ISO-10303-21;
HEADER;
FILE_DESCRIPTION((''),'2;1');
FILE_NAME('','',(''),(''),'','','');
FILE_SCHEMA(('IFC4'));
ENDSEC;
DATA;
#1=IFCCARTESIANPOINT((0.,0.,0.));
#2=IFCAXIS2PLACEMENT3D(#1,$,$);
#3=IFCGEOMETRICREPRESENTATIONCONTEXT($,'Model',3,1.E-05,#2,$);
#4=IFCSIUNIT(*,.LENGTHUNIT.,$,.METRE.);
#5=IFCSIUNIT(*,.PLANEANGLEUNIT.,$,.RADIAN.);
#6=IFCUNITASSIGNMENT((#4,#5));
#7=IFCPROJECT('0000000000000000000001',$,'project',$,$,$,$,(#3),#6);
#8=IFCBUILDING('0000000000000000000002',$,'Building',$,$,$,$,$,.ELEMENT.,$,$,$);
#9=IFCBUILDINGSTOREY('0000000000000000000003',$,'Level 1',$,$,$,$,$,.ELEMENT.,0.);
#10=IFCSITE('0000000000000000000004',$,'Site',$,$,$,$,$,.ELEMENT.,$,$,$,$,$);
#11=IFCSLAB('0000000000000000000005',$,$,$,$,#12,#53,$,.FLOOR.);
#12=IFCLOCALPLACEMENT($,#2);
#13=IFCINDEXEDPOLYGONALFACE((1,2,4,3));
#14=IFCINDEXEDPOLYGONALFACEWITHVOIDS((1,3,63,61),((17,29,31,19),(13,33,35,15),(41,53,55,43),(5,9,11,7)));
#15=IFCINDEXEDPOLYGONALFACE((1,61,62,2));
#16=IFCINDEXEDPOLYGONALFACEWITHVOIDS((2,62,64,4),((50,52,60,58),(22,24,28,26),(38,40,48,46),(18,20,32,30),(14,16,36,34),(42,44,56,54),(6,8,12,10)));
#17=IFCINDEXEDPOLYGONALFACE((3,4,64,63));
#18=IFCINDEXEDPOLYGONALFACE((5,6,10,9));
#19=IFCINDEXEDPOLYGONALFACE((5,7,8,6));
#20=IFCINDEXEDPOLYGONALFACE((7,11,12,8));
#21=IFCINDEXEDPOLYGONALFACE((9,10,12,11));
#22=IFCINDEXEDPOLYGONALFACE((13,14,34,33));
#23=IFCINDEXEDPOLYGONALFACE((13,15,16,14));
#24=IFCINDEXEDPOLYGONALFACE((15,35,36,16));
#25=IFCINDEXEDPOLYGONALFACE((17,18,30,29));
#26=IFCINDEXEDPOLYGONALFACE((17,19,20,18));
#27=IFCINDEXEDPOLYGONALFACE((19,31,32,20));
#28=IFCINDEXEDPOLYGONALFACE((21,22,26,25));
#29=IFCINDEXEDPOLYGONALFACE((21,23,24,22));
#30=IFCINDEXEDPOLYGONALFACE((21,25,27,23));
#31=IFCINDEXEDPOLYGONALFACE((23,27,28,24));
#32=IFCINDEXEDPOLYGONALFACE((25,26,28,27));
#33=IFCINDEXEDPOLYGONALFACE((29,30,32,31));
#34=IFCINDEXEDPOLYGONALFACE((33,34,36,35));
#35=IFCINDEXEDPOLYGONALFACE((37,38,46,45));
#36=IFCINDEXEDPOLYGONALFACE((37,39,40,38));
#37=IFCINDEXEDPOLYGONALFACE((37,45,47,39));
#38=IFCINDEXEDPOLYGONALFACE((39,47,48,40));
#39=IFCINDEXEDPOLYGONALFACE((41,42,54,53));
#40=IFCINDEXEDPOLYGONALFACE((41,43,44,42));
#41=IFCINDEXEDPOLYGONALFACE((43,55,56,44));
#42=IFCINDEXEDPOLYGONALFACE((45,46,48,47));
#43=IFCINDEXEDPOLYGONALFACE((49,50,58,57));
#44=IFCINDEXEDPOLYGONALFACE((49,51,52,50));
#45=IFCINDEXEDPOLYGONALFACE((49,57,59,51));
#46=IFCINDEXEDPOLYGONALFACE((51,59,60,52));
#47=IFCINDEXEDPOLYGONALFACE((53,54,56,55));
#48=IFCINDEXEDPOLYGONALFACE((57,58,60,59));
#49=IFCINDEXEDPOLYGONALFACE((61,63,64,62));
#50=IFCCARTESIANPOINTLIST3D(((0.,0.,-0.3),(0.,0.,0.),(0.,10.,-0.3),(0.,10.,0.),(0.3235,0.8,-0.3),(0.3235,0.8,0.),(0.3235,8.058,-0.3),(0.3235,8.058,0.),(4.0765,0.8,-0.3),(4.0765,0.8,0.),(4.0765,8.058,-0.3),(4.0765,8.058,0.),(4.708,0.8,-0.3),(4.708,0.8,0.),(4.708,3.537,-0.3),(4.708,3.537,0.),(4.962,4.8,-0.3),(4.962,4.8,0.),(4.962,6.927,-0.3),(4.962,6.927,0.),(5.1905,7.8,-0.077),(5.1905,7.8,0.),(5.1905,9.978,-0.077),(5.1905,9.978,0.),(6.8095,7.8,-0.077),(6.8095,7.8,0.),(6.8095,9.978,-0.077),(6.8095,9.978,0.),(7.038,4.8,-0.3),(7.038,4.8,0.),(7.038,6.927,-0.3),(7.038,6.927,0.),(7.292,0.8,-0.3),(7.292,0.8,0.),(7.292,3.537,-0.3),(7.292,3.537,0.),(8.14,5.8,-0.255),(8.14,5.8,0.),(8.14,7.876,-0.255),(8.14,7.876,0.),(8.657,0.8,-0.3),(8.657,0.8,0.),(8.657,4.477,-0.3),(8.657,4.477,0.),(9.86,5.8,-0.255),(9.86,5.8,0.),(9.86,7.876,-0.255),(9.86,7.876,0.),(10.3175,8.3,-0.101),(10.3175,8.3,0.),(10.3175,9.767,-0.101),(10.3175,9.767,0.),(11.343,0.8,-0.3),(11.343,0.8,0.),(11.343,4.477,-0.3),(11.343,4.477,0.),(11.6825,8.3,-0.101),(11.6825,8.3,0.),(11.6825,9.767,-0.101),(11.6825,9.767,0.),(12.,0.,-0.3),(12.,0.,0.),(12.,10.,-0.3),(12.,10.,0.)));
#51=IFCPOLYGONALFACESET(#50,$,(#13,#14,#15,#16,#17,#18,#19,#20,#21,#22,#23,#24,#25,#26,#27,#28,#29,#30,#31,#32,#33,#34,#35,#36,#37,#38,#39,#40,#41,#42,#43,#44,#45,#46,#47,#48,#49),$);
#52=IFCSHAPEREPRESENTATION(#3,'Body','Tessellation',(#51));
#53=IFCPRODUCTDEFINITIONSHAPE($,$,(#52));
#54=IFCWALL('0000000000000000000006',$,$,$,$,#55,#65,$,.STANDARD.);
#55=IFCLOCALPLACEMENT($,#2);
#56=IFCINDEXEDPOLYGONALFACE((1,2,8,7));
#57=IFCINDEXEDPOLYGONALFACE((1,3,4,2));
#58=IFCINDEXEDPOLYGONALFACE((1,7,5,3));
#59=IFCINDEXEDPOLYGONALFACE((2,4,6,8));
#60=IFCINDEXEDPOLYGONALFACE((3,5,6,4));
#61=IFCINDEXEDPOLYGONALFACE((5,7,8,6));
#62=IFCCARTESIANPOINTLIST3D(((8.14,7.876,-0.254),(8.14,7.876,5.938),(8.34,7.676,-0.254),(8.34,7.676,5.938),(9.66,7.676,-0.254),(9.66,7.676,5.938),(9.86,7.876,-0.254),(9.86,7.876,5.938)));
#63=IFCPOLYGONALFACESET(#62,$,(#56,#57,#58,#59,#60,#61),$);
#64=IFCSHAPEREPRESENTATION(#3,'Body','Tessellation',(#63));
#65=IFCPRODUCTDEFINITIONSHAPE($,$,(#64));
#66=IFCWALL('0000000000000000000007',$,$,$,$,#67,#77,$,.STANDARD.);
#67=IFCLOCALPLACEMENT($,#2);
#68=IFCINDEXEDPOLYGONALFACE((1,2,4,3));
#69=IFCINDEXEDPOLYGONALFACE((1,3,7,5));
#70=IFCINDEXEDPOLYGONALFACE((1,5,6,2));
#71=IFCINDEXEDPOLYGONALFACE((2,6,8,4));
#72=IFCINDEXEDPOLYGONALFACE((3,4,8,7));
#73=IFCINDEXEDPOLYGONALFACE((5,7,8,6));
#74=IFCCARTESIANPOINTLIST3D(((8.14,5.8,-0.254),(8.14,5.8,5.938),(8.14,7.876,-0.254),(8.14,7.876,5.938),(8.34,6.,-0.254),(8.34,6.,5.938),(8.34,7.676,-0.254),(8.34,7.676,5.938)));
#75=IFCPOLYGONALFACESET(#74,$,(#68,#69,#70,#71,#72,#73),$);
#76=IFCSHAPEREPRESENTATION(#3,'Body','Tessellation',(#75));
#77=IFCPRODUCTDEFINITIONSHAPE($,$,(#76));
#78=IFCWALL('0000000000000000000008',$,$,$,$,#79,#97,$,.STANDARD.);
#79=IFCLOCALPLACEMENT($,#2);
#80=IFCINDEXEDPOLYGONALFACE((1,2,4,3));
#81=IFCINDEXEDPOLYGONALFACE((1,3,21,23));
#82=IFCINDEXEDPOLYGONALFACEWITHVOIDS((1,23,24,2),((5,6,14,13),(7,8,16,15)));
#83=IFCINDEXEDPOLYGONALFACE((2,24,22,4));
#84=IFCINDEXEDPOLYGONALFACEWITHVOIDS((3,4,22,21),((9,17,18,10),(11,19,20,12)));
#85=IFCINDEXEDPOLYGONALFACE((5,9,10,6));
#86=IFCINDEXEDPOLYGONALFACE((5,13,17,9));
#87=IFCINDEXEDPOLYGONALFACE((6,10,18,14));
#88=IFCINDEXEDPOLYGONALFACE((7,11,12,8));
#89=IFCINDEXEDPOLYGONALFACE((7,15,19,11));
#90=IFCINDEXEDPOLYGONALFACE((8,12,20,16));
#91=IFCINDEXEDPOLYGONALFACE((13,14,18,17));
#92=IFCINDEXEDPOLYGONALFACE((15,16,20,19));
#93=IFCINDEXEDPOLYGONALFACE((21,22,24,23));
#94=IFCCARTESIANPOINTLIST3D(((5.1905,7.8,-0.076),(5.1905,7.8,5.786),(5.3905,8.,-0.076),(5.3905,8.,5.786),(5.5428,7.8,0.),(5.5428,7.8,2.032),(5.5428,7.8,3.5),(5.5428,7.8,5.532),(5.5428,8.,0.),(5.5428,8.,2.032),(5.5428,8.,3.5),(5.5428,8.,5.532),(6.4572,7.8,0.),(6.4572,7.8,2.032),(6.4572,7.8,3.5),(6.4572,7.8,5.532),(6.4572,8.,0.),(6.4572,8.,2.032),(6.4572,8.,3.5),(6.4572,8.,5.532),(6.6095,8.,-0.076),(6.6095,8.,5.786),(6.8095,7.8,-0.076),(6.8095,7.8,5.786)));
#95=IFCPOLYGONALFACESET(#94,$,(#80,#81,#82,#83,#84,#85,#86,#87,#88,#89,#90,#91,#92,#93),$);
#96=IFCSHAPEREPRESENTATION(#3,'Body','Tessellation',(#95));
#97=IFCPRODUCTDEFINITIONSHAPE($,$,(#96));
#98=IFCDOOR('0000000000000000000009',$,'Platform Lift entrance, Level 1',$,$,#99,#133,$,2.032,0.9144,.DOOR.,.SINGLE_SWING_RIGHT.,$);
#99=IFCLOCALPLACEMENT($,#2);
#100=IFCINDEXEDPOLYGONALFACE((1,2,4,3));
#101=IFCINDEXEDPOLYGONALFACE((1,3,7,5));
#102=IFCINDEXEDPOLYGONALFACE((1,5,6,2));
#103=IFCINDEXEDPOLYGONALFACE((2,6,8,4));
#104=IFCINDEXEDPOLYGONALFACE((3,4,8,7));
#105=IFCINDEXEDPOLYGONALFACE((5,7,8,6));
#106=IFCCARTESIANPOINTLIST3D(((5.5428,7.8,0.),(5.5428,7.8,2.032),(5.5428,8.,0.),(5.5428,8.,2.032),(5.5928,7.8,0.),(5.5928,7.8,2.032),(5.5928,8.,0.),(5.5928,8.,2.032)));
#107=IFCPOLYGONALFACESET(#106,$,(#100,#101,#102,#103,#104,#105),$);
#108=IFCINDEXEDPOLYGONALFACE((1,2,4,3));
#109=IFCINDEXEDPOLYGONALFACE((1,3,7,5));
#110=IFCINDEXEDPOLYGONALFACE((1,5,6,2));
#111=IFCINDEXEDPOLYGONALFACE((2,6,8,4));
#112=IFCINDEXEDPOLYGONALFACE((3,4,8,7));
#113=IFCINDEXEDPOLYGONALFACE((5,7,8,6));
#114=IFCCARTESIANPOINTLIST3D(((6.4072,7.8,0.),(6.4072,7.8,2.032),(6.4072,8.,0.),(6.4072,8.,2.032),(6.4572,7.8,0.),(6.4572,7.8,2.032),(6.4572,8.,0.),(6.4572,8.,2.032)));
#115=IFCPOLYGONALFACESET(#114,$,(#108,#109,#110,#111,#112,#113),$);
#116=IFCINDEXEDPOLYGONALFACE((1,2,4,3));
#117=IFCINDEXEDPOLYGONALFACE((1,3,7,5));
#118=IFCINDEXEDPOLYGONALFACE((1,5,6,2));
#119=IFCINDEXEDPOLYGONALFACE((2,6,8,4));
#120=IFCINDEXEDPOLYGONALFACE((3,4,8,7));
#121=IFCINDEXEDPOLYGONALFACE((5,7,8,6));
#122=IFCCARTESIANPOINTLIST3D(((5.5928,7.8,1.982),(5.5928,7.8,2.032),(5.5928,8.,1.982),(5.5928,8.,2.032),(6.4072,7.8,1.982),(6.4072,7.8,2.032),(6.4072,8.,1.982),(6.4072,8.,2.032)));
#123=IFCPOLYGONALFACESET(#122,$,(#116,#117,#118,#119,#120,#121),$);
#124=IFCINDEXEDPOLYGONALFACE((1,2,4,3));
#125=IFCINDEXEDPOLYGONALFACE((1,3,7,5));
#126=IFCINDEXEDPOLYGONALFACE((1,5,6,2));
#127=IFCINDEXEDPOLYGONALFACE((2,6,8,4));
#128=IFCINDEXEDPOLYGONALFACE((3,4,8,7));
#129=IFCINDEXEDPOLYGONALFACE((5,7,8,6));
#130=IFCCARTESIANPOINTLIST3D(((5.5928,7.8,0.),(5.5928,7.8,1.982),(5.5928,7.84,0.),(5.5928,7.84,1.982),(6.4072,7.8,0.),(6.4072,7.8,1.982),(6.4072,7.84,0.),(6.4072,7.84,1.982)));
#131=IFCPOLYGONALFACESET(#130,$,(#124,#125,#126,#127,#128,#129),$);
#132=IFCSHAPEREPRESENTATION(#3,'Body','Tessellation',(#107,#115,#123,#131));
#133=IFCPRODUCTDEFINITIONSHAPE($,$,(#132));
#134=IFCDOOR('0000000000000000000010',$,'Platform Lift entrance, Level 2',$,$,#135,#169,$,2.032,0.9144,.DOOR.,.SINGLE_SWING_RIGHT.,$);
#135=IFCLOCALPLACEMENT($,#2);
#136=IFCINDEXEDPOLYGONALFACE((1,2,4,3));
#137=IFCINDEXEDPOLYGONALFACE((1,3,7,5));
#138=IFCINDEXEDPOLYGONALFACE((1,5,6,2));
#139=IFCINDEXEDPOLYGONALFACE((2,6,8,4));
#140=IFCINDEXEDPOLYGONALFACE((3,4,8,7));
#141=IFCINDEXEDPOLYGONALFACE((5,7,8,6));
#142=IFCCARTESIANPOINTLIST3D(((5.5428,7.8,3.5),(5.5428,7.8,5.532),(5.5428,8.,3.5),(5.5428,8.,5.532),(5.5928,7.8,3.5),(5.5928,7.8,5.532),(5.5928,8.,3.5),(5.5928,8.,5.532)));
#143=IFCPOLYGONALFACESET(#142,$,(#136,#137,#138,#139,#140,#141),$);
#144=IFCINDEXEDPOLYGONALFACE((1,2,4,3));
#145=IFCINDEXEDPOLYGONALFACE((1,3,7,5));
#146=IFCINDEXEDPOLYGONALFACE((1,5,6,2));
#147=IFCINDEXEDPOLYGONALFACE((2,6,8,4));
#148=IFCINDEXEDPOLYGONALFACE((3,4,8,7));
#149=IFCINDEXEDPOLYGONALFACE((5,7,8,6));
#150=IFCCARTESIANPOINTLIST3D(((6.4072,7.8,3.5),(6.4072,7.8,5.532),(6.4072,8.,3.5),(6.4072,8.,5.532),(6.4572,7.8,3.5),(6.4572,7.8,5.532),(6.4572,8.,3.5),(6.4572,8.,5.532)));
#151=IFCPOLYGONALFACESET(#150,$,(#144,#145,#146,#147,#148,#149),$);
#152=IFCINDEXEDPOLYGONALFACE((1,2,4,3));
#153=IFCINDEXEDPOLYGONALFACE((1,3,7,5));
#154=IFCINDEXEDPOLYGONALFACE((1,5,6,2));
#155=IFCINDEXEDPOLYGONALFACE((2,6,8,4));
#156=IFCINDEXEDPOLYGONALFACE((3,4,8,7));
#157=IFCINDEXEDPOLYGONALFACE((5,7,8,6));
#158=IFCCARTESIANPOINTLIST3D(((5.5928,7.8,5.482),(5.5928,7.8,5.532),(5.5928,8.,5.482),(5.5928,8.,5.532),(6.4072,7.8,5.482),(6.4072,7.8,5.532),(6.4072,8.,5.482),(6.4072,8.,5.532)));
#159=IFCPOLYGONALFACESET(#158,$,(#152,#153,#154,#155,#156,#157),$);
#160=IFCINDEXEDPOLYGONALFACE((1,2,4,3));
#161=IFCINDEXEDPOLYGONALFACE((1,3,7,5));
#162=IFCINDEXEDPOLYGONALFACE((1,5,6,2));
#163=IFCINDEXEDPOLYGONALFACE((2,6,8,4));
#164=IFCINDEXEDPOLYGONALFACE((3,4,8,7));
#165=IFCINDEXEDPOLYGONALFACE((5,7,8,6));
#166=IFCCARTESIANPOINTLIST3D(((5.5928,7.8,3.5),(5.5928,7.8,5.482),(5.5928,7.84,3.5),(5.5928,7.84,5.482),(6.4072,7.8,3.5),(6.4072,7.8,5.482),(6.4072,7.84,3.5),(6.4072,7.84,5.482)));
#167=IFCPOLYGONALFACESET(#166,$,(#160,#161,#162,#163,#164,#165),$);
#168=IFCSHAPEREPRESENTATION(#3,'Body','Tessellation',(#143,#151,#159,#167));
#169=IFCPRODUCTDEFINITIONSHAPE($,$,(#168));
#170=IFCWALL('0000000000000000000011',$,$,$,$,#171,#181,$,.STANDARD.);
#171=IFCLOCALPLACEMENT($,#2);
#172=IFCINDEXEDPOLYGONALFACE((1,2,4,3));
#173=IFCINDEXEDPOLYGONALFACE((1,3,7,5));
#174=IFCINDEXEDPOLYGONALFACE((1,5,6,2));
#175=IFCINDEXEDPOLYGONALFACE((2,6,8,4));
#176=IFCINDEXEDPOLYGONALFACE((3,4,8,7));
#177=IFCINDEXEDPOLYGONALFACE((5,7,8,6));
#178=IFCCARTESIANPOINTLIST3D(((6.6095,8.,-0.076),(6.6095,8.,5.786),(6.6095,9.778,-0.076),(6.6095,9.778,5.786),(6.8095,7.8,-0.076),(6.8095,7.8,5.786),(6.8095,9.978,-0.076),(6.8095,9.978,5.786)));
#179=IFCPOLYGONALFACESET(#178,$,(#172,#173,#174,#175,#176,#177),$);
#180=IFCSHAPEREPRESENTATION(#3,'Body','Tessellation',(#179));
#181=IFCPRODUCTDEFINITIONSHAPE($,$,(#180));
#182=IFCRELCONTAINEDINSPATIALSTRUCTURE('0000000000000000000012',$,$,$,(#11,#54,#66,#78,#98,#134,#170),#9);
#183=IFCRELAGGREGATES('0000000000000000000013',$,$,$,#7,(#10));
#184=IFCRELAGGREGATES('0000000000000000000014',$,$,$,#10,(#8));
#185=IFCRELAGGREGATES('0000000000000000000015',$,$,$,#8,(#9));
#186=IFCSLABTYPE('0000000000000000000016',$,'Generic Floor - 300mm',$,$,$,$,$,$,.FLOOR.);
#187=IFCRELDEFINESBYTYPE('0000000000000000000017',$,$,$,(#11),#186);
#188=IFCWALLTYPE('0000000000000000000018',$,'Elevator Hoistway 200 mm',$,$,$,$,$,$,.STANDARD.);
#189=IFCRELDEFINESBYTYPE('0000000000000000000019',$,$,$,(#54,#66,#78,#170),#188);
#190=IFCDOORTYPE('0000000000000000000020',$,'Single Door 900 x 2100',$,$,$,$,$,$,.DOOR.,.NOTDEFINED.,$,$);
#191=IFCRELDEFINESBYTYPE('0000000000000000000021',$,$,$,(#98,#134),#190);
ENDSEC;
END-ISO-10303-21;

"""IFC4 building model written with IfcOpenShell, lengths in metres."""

from ifc_helpers import new_model, si_unit, frame, frame_2d, origin, origin_with_axes, origin_2d, place, context, project, spatial, polyline, rectangle, outline, extrude, type_object, element, fill, save


model = new_model("IFC4")

# Units and contexts
model_context = context("Model", 3, precision=1e-05, world=origin())
ifc_project = project(units=[si_unit("LENGTHUNIT", "METRE"), si_unit("PLANEANGLEUNIT", "RADIAN")], contexts=[model_context])

# Site, building, storey
site = spatial("IfcSite", under=ifc_project, Name="Site", CompositionType="ELEMENT")
building = spatial("IfcBuilding", under=site, Name="Building", CompositionType="ELEMENT")
storey = spatial("IfcBuildingStorey", under=building, Name="Level 1", CompositionType="ELEMENT", Elevation=0.0)

# Slab, openings
slab_type = type_object("IfcSlabType", Name="Generic Floor - 300mm", PredefinedType="FLOOR")
slab_placement = place(None, origin())
slab = element("IfcSlab", 1, at=slab_placement, inside=storey, type_object=slab_type, PredefinedType="FLOOR", context=model_context, shape_type="SweptSolid", body=[
    extrude(outline(polyline([(0.0, 0.0), (12.0, 0.0), (12.0, 10.0), (0.0, 10.0), (0.0, 0.0)])), origin(), (0.0, 0.0, -1.0), 0.3),
])
opening_1_placement = place(None, frame((0.0, 0.0, 0.001)))
element("IfcOpeningElement", 2, at=opening_1_placement, cuts=slab, PredefinedType="OPENING", context=model_context, shape_type="SweptSolid", body=[
    extrude(outline(polyline([(0.3235, 0.8), (4.0765, 0.8), (4.0765, 8.058), (0.3235, 8.058), (0.3235, 0.8)])), origin(), (0.0, 0.0, -1.0), 0.302),
])
opening_2_placement = place(None, frame((0.0, 0.0, 0.001)))
element("IfcOpeningElement", 3, at=opening_2_placement, cuts=slab, PredefinedType="OPENING", context=model_context, shape_type="SweptSolid", body=[
    extrude(outline(polyline([(4.708, 0.8), (7.292, 0.8), (7.292, 3.537), (4.708, 3.537), (4.708, 0.8)])), origin(), (0.0, 0.0, -1.0), 0.302),
])
opening_3_placement = place(None, frame((0.0, 0.0, 0.001)))
element("IfcOpeningElement", 4, at=opening_3_placement, cuts=slab, PredefinedType="OPENING", context=model_context, shape_type="SweptSolid", body=[
    extrude(outline(polyline([(8.657, 0.8), (11.343, 0.8), (11.343, 4.477), (8.657, 4.477), (8.657, 0.8)])), origin(), (0.0, 0.0, -1.0), 0.302),
])
opening_4_placement = place(None, frame((0.0, 0.0, 0.001)))
element("IfcOpeningElement", 5, at=opening_4_placement, cuts=slab, PredefinedType="OPENING", context=model_context, shape_type="SweptSolid", body=[
    extrude(outline(polyline([(4.962, 4.8), (7.038, 4.8), (7.038, 6.927), (4.962, 6.927), (4.962, 4.8)])), origin(), (0.0, 0.0, -1.0), 0.302),
])
opening_5_placement = place(None, frame((0.0, 0.0, 0.001)))
element("IfcOpeningElement", 6, at=opening_5_placement, cuts=slab, PredefinedType="OPENING", context=model_context, shape_type="SweptSolid", body=[
    extrude(outline(polyline([(8.14, 5.8), (9.86, 5.8), (9.86, 7.876), (8.14, 7.876), (8.14, 5.8)])), origin(), (0.0, 0.0, -1.0), 0.256),
])
opening_6_placement = place(None, frame((0.0, 0.0, 0.001)))
element("IfcOpeningElement", 7, at=opening_6_placement, cuts=slab, PredefinedType="OPENING", context=model_context, shape_type="SweptSolid", body=[
    extrude(outline(polyline([(5.1905, 7.8), (6.8095, 7.8), (6.8095, 9.978), (5.1905, 9.978), (5.1905, 7.8)])), origin(), (0.0, 0.0, -1.0), 0.078),
])
opening_7_placement = place(None, frame((0.0, 0.0, 0.001)))
element("IfcOpeningElement", 8, at=opening_7_placement, cuts=slab, PredefinedType="OPENING", context=model_context, shape_type="SweptSolid", body=[
    extrude(outline(polyline([(10.3175, 8.3), (11.6825, 8.3), (11.6825, 9.767), (10.3175, 9.767), (10.3175, 8.3)])), origin(), (0.0, 0.0, -1.0), 0.102),
])

# Walls
wall_type = type_object("IfcWallType", Name="Elevator Hoistway 200 mm", PredefinedType="STANDARD")
wall_1_placement = place(None, frame((9.76, 7.776, -0.254), z_axis=(0.0, 0.0, 1.0), x_axis=(-1.0, 0.0, 0.0)))
element("IfcWall", 9, at=wall_1_placement, inside=storey, type_object=wall_type, PredefinedType="STANDARD", context=model_context, shape_type="SweptSolid", body=[
    extrude(outline(polyline([(-0.1, -0.1), (1.62, -0.1), (1.42, 0.1), (0.1, 0.1), (-0.1, -0.1)])), origin(), (0.0, 0.0, 1.0), 6.192),
])
wall_2_placement = place(None, frame((8.24, 7.776, -0.254), z_axis=(0.0, 0.0, 1.0), x_axis=(0.0, -1.0, 0.0)))
element("IfcWall", 10, at=wall_2_placement, inside=storey, type_object=wall_type, PredefinedType="STANDARD", context=model_context, shape_type="SweptSolid", body=[
    extrude(outline(polyline([(-0.1, -0.1), (1.976, -0.1), (1.776, 0.1), (0.1, 0.1), (-0.1, -0.1)])), origin(), (0.0, 0.0, 1.0), 6.192),
])

# Wall, openings, doors
wall_3_placement = place(None, frame((5.2905, 7.9, -0.076), z_axis=(0.0, 0.0, 1.0), x_axis=(1.0, 0.0, 0.0)))
wall_3 = element("IfcWall", 11, at=wall_3_placement, inside=storey, type_object=wall_type, PredefinedType="STANDARD", context=model_context, shape_type="SweptSolid", body=[
    extrude(outline(polyline([(-0.1, -0.1), (1.519, -0.1), (1.319, 0.1), (0.1, 0.1), (-0.1, -0.1)])), origin(), (0.0, 0.0, 1.0), 5.862),
])
opening_8_placement = place(wall_3_placement, frame((0.7095, 0.0, 0.076), z_axis=(0.0, 0.0, 1.0), x_axis=(1.0, 0.0, 0.0)))
opening_8 = element("IfcOpeningElement", 12, at=opening_8_placement, cuts=wall_3, PredefinedType="OPENING", context=model_context, shape_type="SweptSolid", body=[
    extrude(rectangle(XDim=0.9144, YDim=0.202, at=origin_2d()), origin(), (0.0, 0.0, 1.0), 2.032),
])
opening_9_placement = place(wall_3_placement, frame((0.7095, 0.0, 3.576), z_axis=(0.0, 0.0, 1.0), x_axis=(1.0, 0.0, 0.0)))
opening_9 = element("IfcOpeningElement", 13, at=opening_9_placement, cuts=wall_3, PredefinedType="OPENING", context=model_context, shape_type="SweptSolid", body=[
    extrude(rectangle(XDim=0.9144, YDim=0.202, at=origin_2d()), origin(), (0.0, 0.0, 1.0), 2.032),
])
door_type = type_object("IfcDoorType", Name="Single Door 900 x 2100", OperationType="NOTDEFINED", PredefinedType="DOOR")
door_1_placement = place(opening_8_placement, origin_with_axes())
door_1 = element("IfcDoor", 14, at=door_1_placement, inside=storey, type_object=door_type, Name="Platform Lift entrance, Level 1", OperationType="SINGLE_SWING_RIGHT", OverallHeight=2.032, OverallWidth=0.9144, PredefinedType="DOOR", context=model_context, shape_type="SweptSolid", body=[
    extrude(rectangle(XDim=0.05, YDim=0.2, at=frame_2d((-0.4322, 0.0))), origin(), (0.0, 0.0, 1.0), 2.032),
    extrude(rectangle(XDim=0.05, YDim=0.2, at=frame_2d((0.4322, 0.0))), origin(), (0.0, 0.0, 1.0), 2.032),
    extrude(rectangle(XDim=0.8144, YDim=0.2, at=origin_2d()), frame((0.0, 0.0, 1.982)), (0.0, 0.0, 1.0), 0.05),
    extrude(rectangle(XDim=0.8144, YDim=0.04, at=frame_2d((0.0, -0.08))), origin(), (0.0, 0.0, 1.0), 1.982),
])
fill(opening_8, door_1)
door_2_placement = place(opening_9_placement, origin_with_axes())
door_2 = element("IfcDoor", 15, at=door_2_placement, inside=storey, type_object=door_type, Name="Platform Lift entrance, Level 2", OperationType="SINGLE_SWING_RIGHT", OverallHeight=2.032, OverallWidth=0.9144, PredefinedType="DOOR", context=model_context, shape_type="SweptSolid", body=[
    extrude(rectangle(XDim=0.05, YDim=0.2, at=frame_2d((-0.4322, 0.0))), origin(), (0.0, 0.0, 1.0), 2.032),
    extrude(rectangle(XDim=0.05, YDim=0.2, at=frame_2d((0.4322, 0.0))), origin(), (0.0, 0.0, 1.0), 2.032),
    extrude(rectangle(XDim=0.8144, YDim=0.2, at=origin_2d()), frame((0.0, 0.0, 1.982)), (0.0, 0.0, 1.0), 0.05),
    extrude(rectangle(XDim=0.8144, YDim=0.04, at=frame_2d((0.0, -0.08))), origin(), (0.0, 0.0, 1.0), 1.982),
])
fill(opening_9, door_2)

# Wall
wall_4_placement = place(None, frame((6.7095, 7.9, -0.076), z_axis=(0.0, 0.0, 1.0), x_axis=(0.0, 1.0, 0.0)))
element("IfcWall", 16, at=wall_4_placement, inside=storey, type_object=wall_type, PredefinedType="STANDARD", context=model_context, shape_type="SweptSolid", body=[
    extrude(outline(polyline([(-0.1, -0.1), (2.078, -0.1), (1.878, 0.1), (0.1, 0.1), (-0.1, -0.1)])), origin(), (0.0, 0.0, 1.0), 5.862),
])

save(model, "model.ifc")
